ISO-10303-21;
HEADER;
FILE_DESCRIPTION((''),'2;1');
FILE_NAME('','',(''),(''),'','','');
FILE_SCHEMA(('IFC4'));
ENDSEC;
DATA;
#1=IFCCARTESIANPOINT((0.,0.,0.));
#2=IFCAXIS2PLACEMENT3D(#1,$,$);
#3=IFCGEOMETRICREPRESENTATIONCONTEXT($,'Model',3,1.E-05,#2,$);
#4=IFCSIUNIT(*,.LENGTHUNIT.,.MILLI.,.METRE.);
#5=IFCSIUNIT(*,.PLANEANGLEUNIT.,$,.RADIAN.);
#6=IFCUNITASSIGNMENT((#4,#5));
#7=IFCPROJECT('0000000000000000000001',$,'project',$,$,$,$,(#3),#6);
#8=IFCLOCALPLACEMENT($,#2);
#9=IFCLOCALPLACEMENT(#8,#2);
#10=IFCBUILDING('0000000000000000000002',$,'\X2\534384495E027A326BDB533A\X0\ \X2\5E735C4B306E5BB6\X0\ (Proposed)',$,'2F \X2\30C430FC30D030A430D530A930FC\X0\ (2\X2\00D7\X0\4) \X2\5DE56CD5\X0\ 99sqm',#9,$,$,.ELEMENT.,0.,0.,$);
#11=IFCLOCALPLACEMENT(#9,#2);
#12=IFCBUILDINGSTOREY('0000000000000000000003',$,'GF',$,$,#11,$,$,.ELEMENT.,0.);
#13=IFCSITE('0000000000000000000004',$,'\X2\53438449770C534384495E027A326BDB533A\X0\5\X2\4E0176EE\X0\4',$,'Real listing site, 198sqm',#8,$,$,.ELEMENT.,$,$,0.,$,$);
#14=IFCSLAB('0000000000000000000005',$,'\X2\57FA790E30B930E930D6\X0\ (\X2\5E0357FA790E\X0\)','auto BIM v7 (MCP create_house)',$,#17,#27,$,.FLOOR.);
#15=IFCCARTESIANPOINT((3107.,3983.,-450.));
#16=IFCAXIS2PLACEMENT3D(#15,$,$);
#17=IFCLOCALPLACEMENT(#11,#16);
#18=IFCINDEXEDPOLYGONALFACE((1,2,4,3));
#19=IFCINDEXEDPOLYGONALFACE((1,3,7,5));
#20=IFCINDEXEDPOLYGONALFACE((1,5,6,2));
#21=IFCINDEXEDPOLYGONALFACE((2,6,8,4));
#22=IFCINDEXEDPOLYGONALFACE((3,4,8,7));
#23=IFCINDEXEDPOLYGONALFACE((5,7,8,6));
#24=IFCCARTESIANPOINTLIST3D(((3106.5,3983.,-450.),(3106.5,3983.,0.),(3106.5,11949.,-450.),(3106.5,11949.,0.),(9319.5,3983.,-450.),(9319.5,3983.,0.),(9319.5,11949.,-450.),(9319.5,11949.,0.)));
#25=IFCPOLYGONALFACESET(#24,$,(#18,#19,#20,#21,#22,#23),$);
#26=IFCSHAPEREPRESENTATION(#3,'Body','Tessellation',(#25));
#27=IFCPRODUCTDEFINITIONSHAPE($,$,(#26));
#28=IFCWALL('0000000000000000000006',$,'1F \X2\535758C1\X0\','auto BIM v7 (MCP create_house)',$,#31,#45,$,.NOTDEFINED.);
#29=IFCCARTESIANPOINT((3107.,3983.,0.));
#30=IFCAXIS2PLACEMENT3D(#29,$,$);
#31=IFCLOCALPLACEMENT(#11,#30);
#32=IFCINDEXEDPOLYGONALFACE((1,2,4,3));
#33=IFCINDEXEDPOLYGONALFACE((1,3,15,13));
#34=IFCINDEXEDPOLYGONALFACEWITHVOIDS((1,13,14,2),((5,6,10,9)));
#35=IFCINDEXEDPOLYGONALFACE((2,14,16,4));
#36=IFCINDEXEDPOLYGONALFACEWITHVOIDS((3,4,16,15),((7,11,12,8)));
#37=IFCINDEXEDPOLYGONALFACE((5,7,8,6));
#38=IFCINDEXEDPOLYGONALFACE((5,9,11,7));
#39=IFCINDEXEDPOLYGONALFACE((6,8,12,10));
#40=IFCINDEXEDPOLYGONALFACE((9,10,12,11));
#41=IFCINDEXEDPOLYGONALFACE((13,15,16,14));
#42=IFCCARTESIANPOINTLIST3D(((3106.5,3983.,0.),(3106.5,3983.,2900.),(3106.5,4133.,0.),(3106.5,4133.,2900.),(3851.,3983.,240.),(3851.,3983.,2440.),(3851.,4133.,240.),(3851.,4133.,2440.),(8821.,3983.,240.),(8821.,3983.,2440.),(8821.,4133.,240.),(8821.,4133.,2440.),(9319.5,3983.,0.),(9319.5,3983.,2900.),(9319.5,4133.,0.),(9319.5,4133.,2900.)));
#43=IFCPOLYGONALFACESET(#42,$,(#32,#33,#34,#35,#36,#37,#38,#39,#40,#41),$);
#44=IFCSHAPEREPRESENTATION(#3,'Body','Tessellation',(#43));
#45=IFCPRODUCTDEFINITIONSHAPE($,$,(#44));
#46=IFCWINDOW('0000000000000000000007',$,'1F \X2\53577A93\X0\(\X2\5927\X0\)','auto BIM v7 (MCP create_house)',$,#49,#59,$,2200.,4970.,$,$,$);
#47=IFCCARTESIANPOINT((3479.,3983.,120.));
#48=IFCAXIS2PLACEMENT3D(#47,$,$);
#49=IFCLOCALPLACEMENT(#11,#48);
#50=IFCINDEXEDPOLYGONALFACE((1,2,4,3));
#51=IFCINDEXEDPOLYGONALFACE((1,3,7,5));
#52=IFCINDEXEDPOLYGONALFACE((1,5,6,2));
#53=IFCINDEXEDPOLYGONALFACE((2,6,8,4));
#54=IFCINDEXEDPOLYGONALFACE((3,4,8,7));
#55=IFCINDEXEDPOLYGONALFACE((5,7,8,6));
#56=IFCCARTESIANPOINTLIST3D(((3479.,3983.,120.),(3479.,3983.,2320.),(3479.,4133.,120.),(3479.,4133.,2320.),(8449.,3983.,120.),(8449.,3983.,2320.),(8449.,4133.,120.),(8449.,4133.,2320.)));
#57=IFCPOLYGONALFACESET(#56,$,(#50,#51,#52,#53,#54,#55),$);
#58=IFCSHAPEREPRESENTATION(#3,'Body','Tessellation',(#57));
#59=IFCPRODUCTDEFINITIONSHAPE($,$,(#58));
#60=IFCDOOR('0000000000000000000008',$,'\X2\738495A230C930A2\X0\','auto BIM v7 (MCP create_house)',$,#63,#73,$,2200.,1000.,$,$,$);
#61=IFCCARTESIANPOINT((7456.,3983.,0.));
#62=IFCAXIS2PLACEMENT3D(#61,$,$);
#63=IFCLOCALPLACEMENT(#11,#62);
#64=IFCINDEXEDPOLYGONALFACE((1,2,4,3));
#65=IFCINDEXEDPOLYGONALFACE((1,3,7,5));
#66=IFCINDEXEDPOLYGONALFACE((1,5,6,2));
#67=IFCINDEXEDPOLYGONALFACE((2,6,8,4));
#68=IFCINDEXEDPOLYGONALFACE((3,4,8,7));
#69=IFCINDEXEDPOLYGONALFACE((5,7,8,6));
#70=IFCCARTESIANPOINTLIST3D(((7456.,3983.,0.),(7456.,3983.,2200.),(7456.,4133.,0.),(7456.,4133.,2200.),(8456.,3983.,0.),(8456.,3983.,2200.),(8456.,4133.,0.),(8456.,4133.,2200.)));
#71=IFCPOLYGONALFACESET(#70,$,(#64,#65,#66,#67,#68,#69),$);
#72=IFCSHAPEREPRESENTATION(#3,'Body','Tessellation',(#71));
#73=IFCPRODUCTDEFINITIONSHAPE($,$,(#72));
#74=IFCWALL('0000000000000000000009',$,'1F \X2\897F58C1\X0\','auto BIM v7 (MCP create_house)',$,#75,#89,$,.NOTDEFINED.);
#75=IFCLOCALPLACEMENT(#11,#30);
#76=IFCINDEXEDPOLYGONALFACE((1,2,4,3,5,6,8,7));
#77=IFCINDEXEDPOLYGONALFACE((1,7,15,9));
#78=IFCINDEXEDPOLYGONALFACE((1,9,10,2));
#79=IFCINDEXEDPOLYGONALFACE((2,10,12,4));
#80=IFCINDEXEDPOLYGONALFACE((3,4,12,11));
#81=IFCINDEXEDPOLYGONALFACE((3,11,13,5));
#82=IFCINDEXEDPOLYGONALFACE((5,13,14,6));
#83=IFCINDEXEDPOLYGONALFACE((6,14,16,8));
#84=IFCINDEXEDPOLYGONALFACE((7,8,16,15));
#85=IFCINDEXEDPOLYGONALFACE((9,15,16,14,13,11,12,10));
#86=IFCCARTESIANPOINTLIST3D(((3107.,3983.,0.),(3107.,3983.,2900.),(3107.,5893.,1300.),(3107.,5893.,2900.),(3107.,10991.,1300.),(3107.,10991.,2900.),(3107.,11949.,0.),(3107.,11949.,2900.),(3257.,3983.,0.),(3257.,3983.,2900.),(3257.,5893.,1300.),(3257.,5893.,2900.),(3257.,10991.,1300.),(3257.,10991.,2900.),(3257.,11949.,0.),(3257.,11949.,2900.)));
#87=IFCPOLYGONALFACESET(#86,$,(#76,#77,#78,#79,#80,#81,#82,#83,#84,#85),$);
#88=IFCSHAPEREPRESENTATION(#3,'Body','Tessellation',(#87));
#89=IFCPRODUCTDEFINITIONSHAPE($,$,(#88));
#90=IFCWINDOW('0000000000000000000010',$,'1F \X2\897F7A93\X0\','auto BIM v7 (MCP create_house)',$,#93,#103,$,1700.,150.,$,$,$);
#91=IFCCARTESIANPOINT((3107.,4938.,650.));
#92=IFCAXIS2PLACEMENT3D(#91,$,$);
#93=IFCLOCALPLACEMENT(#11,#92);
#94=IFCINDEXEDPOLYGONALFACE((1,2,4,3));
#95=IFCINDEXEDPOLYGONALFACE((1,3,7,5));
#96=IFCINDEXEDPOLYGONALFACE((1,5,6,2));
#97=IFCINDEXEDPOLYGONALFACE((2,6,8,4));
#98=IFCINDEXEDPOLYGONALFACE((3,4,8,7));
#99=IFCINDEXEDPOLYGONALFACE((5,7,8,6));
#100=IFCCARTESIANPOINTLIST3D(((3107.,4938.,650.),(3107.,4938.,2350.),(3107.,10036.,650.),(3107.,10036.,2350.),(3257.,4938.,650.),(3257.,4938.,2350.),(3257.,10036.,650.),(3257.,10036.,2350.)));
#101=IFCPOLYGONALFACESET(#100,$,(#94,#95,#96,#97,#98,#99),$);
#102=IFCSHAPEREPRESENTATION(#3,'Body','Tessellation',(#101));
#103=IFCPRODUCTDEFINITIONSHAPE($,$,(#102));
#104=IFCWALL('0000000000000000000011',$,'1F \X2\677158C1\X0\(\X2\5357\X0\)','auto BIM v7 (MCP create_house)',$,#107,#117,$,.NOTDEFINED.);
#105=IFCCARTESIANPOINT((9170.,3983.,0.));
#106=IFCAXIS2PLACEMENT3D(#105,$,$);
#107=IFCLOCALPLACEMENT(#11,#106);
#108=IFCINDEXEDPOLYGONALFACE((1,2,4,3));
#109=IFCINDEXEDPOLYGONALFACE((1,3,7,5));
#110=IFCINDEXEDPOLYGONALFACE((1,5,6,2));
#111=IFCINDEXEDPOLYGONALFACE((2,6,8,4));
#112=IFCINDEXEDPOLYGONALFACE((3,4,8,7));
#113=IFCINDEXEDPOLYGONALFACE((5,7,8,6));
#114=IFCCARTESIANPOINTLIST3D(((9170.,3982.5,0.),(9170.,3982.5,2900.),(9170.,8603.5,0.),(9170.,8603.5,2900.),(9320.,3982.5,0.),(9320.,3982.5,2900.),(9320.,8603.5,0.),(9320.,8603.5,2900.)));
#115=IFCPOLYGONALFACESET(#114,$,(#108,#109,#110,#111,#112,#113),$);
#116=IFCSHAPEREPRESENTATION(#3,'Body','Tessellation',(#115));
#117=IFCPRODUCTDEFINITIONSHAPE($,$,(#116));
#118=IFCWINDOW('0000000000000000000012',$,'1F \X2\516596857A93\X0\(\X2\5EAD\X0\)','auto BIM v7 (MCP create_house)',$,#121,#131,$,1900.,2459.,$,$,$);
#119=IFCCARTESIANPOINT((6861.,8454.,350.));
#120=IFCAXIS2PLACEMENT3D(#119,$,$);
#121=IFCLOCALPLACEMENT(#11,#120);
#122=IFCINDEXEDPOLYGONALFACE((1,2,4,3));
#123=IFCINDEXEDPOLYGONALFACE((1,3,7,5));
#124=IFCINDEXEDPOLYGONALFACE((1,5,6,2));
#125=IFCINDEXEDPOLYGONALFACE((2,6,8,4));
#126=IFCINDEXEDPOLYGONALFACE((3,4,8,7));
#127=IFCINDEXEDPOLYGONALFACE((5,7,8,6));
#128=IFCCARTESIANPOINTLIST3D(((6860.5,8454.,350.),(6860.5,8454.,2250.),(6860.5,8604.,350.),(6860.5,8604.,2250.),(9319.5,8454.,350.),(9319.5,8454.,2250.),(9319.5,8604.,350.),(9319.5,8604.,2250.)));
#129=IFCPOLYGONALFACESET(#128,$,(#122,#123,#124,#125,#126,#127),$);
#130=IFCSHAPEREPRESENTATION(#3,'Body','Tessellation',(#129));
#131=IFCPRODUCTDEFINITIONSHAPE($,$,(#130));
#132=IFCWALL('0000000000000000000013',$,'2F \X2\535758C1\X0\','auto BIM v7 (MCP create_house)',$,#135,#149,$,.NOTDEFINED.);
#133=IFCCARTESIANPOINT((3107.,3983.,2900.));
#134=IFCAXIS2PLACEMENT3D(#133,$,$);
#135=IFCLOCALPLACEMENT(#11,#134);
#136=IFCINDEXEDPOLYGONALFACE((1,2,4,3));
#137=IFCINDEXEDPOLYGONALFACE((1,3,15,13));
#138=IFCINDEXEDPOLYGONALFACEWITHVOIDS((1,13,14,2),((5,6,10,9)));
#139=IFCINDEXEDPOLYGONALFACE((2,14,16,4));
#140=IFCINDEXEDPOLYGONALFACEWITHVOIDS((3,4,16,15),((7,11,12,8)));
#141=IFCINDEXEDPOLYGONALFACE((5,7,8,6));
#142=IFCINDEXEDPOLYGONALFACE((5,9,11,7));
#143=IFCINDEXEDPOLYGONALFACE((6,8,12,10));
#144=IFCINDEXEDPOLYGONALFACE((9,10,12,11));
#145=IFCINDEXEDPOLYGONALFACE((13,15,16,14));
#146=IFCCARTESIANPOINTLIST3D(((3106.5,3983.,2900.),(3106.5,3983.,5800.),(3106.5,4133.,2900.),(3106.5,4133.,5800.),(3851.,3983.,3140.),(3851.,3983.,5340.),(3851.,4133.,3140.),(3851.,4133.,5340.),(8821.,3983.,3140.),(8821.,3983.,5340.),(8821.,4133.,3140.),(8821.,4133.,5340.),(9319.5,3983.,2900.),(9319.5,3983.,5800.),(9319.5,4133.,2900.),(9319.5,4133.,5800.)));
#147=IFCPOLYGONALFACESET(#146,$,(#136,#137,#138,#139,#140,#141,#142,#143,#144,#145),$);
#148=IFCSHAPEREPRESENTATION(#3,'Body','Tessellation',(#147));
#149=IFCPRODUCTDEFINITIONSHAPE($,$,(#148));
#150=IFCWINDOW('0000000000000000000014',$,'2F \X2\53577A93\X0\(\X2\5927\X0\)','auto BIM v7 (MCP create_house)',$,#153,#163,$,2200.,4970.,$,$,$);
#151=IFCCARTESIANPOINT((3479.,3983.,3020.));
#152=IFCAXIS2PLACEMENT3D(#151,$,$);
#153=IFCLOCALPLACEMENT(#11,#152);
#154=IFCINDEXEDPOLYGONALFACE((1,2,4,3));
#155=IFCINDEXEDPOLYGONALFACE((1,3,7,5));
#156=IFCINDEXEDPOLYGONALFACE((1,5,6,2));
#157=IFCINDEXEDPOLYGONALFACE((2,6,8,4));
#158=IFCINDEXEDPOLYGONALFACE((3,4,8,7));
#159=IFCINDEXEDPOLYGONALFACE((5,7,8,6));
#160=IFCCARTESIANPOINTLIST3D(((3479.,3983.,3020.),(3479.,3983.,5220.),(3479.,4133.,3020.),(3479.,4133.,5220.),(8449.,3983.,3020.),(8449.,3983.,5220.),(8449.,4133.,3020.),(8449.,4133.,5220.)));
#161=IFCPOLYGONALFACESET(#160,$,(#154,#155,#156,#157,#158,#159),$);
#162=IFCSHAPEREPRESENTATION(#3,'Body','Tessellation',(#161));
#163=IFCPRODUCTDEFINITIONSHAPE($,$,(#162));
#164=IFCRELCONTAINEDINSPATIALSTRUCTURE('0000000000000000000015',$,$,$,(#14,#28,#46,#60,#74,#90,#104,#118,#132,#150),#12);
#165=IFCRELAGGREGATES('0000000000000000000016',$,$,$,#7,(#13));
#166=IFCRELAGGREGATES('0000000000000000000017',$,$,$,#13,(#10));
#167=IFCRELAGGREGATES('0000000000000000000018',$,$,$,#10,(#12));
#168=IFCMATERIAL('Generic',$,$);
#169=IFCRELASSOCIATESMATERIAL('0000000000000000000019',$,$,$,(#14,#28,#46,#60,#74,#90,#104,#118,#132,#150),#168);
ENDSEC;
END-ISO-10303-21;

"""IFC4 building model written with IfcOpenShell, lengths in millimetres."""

from ifc_helpers import new_model, si_unit, frame, frame_2d, origin, place, context, project, spatial, rectangle, extrude, material, element, fill, save


model = new_model("IFC4")

# Units and contexts
model_context = context("Model", 3, precision=1e-05, world=origin())
ifc_project = project(units=[si_unit("LENGTHUNIT", "METRE", prefix="MILLI"), si_unit("PLANEANGLEUNIT", "RADIAN")], contexts=[model_context])

# Site, building, storey
site_placement = place(None, origin())
site = spatial("IfcSite", under=ifc_project, at=site_placement, Name="千葉県千葉市稲毛区5丁目4", ObjectType="Real listing site, 198sqm", CompositionType="ELEMENT", RefElevation=0.0)
building_placement = place(site_placement, origin())
building = spatial("IfcBuilding", under=site, at=building_placement, Name="千葉市稲毛区 平屋の家 (Proposed)", ObjectType="2F ツーバイフォー (2×4) 工法 99sqm", CompositionType="ELEMENT", ElevationOfRefHeight=0.0, ElevationOfTerrain=0.0)
storey_placement = place(building_placement, origin())
storey = spatial("IfcBuildingStorey", under=building, at=storey_placement, Name="GF", CompositionType="ELEMENT", Elevation=0.0)

# Slab
ifc_material = material(Name="Generic")
slab_1_placement = place(storey_placement, frame((3107.0, 3983.0, -450.0)))
element("IfcSlab", 1, at=slab_1_placement, inside=storey, material=ifc_material, Name="基礎スラブ (布基礎)", Description="auto BIM v7 (MCP create_house)", PredefinedType="FLOOR", context=model_context, shape_type="SweptSolid", body=[
    extrude(rectangle(XDim=6213.0, YDim=7966.0, at=frame_2d((3106.0, 3983.0))), frame((3107.0, 3983.0, -450.0)), (0.0, 0.0, 1.0), 450.0),
])

# Wall, openings, window, door
wall_1_placement = place(storey_placement, frame((3107.0, 3983.0, 0.0)))
wall_1 = element("IfcWall", 2, at=wall_1_placement, inside=storey, material=ifc_material, Name="1F 南壁", Description="auto BIM v7 (MCP create_house)", PredefinedType="NOTDEFINED", context=model_context, shape_type="SweptSolid", body=[
    extrude(rectangle(XDim=6213.0, YDim=150.0, at=frame_2d((3106.0, 75.0))), frame((3107.0, 3983.0, 0.0)), (0.0, 0.0, 1.0), 2900.0),
])
opening_1_placement = place(storey_placement, frame((3479.0, 3983.0, 120.0)))
opening_1 = element("IfcOpeningElement", 3, at=opening_1_placement, cuts=wall_1, PredefinedType="NOTDEFINED", context=model_context, shape_type="SweptSolid", body=[
    extrude(rectangle(XDim=4970.0, YDim=150.0, at=frame_2d((2485.0, 75.0))), frame((3479.0, 3983.0, 120.0)), (0.0, 0.0, 1.0), 2200.0),
])
opening_2_placement = place(storey_placement, frame((7456.0, 3983.0, 0.0)))
opening_2 = element("IfcOpeningElement", 4, at=opening_2_placement, cuts=wall_1, PredefinedType="NOTDEFINED", context=model_context, shape_type="SweptSolid", body=[
    extrude(rectangle(XDim=1000.0, YDim=150.0, at=frame_2d((500.0, 75.0))), frame((7456.0, 3983.0, 0.0)), (0.0, 0.0, 1.0), 2200.0),
])
window_1_placement = place(storey_placement, frame((3479.0, 3983.0, 120.0)))
window_1 = element("IfcWindow", 5, at=window_1_placement, inside=storey, material=ifc_material, Name="1F 南窓(大)", Description="auto BIM v7 (MCP create_house)", OverallHeight=2200.0, OverallWidth=4970.0, context=model_context, shape_type="SweptSolid", body=[
    extrude(rectangle(XDim=4970.0, YDim=150.0, at=frame_2d((2485.0, 75.0))), frame((3479.0, 3983.0, 120.0)), (0.0, 0.0, 1.0), 2200.0),
])
fill(opening_1, window_1)
door_placement = place(storey_placement, frame((7456.0, 3983.0, 0.0)))
door = element("IfcDoor", 6, at=door_placement, inside=storey, material=ifc_material, Name="玄関ドア", Description="auto BIM v7 (MCP create_house)", OverallHeight=2200.0, OverallWidth=1000.0, context=model_context, shape_type="SweptSolid", body=[
    extrude(rectangle(XDim=1000.0, YDim=150.0, at=frame_2d((500.0, 75.0))), frame((7456.0, 3983.0, 0.0)), (0.0, 0.0, 1.0), 2200.0),
])
fill(opening_2, door)

# Walls, openings, windows
wall_2_placement = place(storey_placement, frame((3107.0, 3983.0, 0.0)))
wall_2 = element("IfcWall", 7, at=wall_2_placement, inside=storey, material=ifc_material, Name="1F 西壁", Description="auto BIM v7 (MCP create_house)", PredefinedType="NOTDEFINED", context=model_context, shape_type="SweptSolid", body=[
    extrude(rectangle(XDim=150.0, YDim=7966.0, at=frame_2d((75.0, 3983.0))), frame((3107.0, 3983.0, 0.0)), (0.0, 0.0, 1.0), 2900.0),
])
opening_3_placement = place(storey_placement, frame((3107.0, 4938.0, 650.0)))
opening_3 = element("IfcOpeningElement", 8, at=opening_3_placement, cuts=wall_2, PredefinedType="NOTDEFINED", context=model_context, shape_type="SweptSolid", body=[
    extrude(rectangle(XDim=150.0, YDim=5098.0, at=frame_2d((75.0, 2549.0))), frame((3107.0, 4938.0, 650.0)), (0.0, 0.0, 1.0), 1700.0),
])
window_2_placement = place(storey_placement, frame((3107.0, 4938.0, 650.0)))
window_2 = element("IfcWindow", 9, at=window_2_placement, inside=storey, material=ifc_material, Name="1F 西窓", Description="auto BIM v7 (MCP create_house)", OverallHeight=1700.0, OverallWidth=150.0, context=model_context, shape_type="SweptSolid", body=[
    extrude(rectangle(XDim=150.0, YDim=5098.0, at=frame_2d((75.0, 2549.0))), frame((3107.0, 4938.0, 650.0)), (0.0, 0.0, 1.0), 1700.0),
])
fill(opening_3, window_2)
wall_3_placement = place(storey_placement, frame((9170.0, 3983.0, 0.0)))
wall_3 = element("IfcWall", 10, at=wall_3_placement, inside=storey, material=ifc_material, Name="1F 東壁(南)", Description="auto BIM v7 (MCP create_house)", PredefinedType="NOTDEFINED", context=model_context, shape_type="SweptSolid", body=[
    extrude(rectangle(XDim=150.0, YDim=4621.0, at=frame_2d((75.0, 2310.0))), frame((9170.0, 3983.0, 0.0)), (0.0, 0.0, 1.0), 2900.0),
])
opening_4_placement = place(storey_placement, frame((6861.0, 8454.0, 350.0)))
opening_4 = element("IfcOpeningElement", 11, at=opening_4_placement, cuts=wall_3, PredefinedType="NOTDEFINED", context=model_context, shape_type="SweptSolid", body=[
    extrude(rectangle(XDim=2459.0, YDim=150.0, at=frame_2d((1229.0, 75.0))), frame((6861.0, 8454.0, 350.0)), (0.0, 0.0, 1.0), 1900.0),
])
window_3_placement = place(storey_placement, frame((6861.0, 8454.0, 350.0)))
window_3 = element("IfcWindow", 12, at=window_3_placement, inside=storey, material=ifc_material, Name="1F 入隅窓(庭)", Description="auto BIM v7 (MCP create_house)", OverallHeight=1900.0, OverallWidth=2459.0, context=model_context, shape_type="SweptSolid", body=[
    extrude(rectangle(XDim=2459.0, YDim=150.0, at=frame_2d((1229.0, 75.0))), frame((6861.0, 8454.0, 350.0)), (0.0, 0.0, 1.0), 1900.0),
])
fill(opening_4, window_3)

# Wall, opening, window
wall_4_placement = place(storey_placement, frame((3107.0, 3983.0, 2900.0)))
wall_4 = element("IfcWall", 13, at=wall_4_placement, inside=storey, material=ifc_material, Name="2F 南壁", Description="auto BIM v7 (MCP create_house)", PredefinedType="NOTDEFINED", context=model_context, shape_type="SweptSolid", body=[
    extrude(rectangle(XDim=6213.0, YDim=150.0, at=frame_2d((3106.0, 75.0))), frame((3107.0, 3983.0, 2900.0)), (0.0, 0.0, 1.0), 2900.0),
])
opening_5_placement = place(storey_placement, frame((3479.0, 3983.0, 3020.0)))
opening_5 = element("IfcOpeningElement", 14, at=opening_5_placement, cuts=wall_4, PredefinedType="NOTDEFINED", context=model_context, shape_type="SweptSolid", body=[
    extrude(rectangle(XDim=4970.0, YDim=150.0, at=frame_2d((2485.0, 75.0))), frame((3479.0, 3983.0, 3020.0)), (0.0, 0.0, 1.0), 2200.0),
])
window_4_placement = place(storey_placement, frame((3479.0, 3983.0, 3020.0)))
window_4 = element("IfcWindow", 15, at=window_4_placement, inside=storey, material=ifc_material, Name="2F 南窓(大)", Description="auto BIM v7 (MCP create_house)", OverallHeight=2200.0, OverallWidth=4970.0, context=model_context, shape_type="SweptSolid", body=[
    extrude(rectangle(XDim=4970.0, YDim=150.0, at=frame_2d((2485.0, 75.0))), frame((3479.0, 3983.0, 3020.0)), (0.0, 0.0, 1.0), 2200.0),
])
fill(opening_5, window_4)

save(model, "model.ifc")
